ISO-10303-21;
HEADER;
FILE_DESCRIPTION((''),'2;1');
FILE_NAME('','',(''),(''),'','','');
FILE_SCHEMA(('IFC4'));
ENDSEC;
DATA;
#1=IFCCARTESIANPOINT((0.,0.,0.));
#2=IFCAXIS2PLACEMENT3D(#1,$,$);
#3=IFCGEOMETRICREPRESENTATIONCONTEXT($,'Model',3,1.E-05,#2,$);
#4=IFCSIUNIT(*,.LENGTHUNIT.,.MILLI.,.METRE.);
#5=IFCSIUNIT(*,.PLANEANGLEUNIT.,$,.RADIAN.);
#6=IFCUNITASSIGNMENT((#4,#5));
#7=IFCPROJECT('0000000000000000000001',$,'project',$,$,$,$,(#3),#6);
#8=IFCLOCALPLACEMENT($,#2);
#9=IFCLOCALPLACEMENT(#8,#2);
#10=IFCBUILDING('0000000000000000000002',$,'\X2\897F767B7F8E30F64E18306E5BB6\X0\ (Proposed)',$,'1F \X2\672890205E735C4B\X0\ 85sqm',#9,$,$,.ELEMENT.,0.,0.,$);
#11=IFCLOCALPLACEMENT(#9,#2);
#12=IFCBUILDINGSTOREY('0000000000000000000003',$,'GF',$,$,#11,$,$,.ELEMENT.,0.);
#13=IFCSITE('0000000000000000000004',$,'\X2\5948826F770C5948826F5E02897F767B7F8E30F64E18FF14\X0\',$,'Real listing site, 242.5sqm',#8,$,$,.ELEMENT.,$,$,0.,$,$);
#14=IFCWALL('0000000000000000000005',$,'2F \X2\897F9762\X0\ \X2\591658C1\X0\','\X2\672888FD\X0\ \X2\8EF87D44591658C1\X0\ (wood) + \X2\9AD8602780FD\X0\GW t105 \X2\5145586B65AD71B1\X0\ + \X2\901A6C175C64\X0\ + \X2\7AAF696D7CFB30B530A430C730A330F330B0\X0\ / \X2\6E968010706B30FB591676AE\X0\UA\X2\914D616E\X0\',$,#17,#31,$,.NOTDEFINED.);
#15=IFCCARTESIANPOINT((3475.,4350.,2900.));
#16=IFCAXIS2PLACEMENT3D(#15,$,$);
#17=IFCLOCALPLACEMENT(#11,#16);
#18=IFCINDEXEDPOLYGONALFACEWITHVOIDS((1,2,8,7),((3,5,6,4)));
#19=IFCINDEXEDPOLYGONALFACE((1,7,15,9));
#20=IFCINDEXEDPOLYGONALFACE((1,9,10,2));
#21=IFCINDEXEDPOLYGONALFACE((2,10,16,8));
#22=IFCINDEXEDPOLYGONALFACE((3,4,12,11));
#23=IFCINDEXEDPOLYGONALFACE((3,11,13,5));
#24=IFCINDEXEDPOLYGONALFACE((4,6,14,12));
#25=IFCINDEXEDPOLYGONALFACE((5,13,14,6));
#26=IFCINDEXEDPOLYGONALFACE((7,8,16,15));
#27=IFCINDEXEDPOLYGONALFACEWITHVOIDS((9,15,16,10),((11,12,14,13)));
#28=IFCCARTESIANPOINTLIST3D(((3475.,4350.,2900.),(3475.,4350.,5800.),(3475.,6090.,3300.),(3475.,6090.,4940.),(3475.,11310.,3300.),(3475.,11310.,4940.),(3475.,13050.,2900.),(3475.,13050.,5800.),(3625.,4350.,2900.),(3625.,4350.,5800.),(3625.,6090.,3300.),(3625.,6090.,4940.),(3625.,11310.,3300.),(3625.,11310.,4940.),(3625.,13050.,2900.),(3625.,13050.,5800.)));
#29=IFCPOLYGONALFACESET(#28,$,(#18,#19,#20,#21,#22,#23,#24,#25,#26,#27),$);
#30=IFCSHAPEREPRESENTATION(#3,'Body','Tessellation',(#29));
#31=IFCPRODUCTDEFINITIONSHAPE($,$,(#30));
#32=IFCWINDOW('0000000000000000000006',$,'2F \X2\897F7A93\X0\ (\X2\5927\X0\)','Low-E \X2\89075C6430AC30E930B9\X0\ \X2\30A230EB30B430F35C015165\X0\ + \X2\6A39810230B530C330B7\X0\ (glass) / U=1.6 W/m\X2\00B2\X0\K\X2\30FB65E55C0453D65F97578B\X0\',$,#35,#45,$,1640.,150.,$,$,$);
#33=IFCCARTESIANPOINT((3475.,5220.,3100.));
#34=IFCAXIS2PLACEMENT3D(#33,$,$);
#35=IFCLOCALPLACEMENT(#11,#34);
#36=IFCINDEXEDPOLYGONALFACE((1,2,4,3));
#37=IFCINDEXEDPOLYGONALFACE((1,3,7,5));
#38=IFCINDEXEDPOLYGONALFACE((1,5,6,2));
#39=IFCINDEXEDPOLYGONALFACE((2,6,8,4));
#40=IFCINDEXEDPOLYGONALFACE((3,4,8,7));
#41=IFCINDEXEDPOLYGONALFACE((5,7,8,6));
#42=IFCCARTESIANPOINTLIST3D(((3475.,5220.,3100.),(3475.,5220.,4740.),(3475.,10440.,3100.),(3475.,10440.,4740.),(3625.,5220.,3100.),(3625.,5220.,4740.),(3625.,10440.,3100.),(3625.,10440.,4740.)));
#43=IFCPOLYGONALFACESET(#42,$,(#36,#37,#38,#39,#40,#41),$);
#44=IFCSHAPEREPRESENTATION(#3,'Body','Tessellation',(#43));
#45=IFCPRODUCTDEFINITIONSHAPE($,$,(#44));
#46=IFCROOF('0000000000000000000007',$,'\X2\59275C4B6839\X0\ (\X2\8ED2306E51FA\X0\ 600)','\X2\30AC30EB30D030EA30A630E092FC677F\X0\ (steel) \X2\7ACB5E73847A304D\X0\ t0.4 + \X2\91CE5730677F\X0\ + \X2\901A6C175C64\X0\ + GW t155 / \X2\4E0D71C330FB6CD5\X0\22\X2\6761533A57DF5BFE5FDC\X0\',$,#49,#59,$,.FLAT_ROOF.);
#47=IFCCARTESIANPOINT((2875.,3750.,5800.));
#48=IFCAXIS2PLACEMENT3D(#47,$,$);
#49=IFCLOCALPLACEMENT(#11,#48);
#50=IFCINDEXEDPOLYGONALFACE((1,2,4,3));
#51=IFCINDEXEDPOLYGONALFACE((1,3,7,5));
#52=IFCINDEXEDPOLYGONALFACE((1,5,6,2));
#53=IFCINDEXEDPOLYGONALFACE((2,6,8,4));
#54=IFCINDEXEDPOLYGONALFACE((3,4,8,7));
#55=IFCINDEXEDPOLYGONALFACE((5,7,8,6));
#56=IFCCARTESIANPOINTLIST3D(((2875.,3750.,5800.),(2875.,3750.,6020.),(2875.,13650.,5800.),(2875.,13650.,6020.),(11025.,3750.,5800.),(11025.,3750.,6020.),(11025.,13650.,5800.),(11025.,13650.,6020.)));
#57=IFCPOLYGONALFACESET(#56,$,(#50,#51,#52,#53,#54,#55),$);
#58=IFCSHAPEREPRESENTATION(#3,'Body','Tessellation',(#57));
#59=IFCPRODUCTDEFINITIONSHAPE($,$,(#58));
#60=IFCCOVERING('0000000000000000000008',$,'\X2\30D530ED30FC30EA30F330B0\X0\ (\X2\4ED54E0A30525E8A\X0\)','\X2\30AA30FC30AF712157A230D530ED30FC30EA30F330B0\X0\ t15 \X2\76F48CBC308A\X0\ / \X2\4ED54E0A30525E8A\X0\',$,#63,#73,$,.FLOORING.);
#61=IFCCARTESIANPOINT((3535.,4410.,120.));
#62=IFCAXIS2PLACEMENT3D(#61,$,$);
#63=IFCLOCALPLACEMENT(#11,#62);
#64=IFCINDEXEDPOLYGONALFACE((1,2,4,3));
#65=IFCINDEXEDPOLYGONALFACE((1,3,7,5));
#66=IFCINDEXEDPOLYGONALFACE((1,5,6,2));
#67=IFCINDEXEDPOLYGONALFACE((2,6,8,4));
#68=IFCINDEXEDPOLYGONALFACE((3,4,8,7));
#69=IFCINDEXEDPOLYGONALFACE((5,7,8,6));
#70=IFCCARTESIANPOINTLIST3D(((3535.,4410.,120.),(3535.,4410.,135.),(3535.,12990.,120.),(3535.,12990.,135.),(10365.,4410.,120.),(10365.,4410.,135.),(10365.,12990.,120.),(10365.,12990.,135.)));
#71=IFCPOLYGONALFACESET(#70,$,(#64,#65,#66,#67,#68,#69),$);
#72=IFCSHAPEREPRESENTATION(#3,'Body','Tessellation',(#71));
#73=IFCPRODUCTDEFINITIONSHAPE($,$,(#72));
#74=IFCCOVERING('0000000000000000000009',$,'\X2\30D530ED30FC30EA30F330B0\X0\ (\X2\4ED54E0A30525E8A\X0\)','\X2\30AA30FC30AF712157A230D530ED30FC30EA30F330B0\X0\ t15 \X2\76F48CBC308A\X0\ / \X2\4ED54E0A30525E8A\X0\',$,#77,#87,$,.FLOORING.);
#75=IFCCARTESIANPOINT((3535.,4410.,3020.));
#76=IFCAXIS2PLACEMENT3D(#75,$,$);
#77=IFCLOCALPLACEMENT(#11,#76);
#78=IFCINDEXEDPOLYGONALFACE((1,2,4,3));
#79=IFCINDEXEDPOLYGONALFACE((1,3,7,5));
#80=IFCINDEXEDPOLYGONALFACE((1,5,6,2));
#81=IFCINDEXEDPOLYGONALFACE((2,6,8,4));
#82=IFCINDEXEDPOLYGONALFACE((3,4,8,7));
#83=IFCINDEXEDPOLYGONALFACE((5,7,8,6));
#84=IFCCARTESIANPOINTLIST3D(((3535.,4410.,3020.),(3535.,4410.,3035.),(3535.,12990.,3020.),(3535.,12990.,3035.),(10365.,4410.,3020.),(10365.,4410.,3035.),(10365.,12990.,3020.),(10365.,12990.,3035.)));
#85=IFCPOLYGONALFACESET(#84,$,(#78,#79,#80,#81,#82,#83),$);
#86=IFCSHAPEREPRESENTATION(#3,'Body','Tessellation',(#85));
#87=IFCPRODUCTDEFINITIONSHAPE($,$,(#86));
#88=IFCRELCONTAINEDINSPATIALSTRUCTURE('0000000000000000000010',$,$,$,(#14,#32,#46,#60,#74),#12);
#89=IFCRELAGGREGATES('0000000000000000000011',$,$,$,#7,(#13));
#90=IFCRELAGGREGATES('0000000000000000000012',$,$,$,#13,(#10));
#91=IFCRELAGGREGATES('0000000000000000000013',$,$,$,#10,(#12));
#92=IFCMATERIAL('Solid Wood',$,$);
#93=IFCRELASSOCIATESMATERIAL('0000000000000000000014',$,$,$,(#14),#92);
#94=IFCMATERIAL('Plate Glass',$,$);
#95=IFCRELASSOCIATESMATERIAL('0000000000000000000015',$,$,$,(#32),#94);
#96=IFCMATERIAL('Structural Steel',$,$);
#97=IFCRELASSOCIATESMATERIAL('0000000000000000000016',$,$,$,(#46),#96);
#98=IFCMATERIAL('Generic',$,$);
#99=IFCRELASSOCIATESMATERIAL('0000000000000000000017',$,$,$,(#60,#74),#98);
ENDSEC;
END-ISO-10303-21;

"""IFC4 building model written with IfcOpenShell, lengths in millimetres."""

from ifc_helpers import new_model, si_unit, frame, frame_2d, origin, place, context, project, spatial, rectangle, extrude, material, element, fill, save


model = new_model("IFC4")

# Units and contexts
model_context = context("Model", 3, precision=1e-05, world=origin())
ifc_project = project(units=[si_unit("LENGTHUNIT", "METRE", prefix="MILLI"), si_unit("PLANEANGLEUNIT", "RADIAN")], contexts=[model_context])

# Site, building, storey
site_placement = place(None, origin())
site = spatial("IfcSite", under=ifc_project, at=site_placement, Name="奈良県奈良市西登美ヶ丘４", ObjectType="Real listing site, 242.5sqm", CompositionType="ELEMENT", RefElevation=0.0)
building_placement = place(site_placement, origin())
building = spatial("IfcBuilding", under=site, at=building_placement, Name="西登美ヶ丘の家 (Proposed)", ObjectType="1F 木造平屋 85sqm", CompositionType="ELEMENT", ElevationOfRefHeight=0.0, ElevationOfTerrain=0.0)
storey_placement = place(building_placement, origin())
storey = spatial("IfcBuildingStorey", under=building, at=storey_placement, Name="GF", CompositionType="ELEMENT", Elevation=0.0)

# Shared definitions
ifc_material_1 = material(Name="Solid Wood")
ifc_material_2 = material(Name="Generic")

# Shared definitions
ifc_material_3 = material(Name="Plate Glass")

# Wall, opening, window
wall_1_placement = place(storey_placement, frame((3475.0, 4350.0, 2900.0)))
wall_1 = element("IfcWall", 1, at=wall_1_placement, inside=storey, material=ifc_material_1, Name="2F 西面 外壁", Description="木製 軸組外壁 (wood) + 高性能GW t105 充填断熱 + 通気層 + 窯業系サイディング / 準耐火・外皮UA配慮", PredefinedType="NOTDEFINED", context=model_context, shape_type="SweptSolid", body=[
    extrude(rectangle(XDim=150.0, YDim=8700.0, at=frame_2d((75.0, 4350.0))), frame((3475.0, 4350.0, 2900.0)), (0.0, 0.0, 1.0), 2900.0),
])
opening_1_placement = place(storey_placement, frame((3475.0, 5220.0, 3100.0)))
opening_1 = element("IfcOpeningElement", 2, at=opening_1_placement, cuts=wall_1, PredefinedType="NOTDEFINED", context=model_context, shape_type="SweptSolid", body=[
    extrude(rectangle(XDim=150.0, YDim=5220.0, at=frame_2d((75.0, 2610.0))), frame((3475.0, 5220.0, 3100.0)), (0.0, 0.0, 1.0), 1640.0),
])
window_1_placement = place(storey_placement, frame((3475.0, 5220.0, 3100.0)))
window_1 = element("IfcWindow", 3, at=window_1_placement, inside=storey, material=ifc_material_3, Name="2F 西窓 (大)", Description="Low-E 複層ガラス アルゴン封入 + 樹脂サッシ (glass) / U=1.6 W/m²K・日射取得型", OverallHeight=1640.0, OverallWidth=150.0, context=model_context, shape_type="SweptSolid", body=[
    extrude(rectangle(XDim=150.0, YDim=5220.0, at=frame_2d((75.0, 2610.0))), frame((3475.0, 5220.0, 3100.0)), (0.0, 0.0, 1.0), 1640.0),
])
fill(opening_1, window_1)

# Roof
ifc_material_4 = material(Name="Structural Steel")
roof_placement = place(storey_placement, frame((2875.0, 3750.0, 5800.0)))
element("IfcRoof", 4, at=roof_placement, inside=storey, material=ifc_material_4, Name="大屋根 (軒の出 600)", Description="ガルバリウム鋼板 (steel) 立平葺き t0.4 + 野地板 + 通気層 + GW t155 / 不燃・法22条区域対応", PredefinedType="FLAT_ROOF", context=model_context, shape_type="SweptSolid", body=[
    extrude(rectangle(XDim=8150.0, YDim=9900.0, at=frame_2d((4075.0, 4950.0))), frame((2875.0, 3750.0, 5800.0)), (0.0, 0.0, 1.0), 220.0),
])

# Coverings
covering_1_placement = place(storey_placement, frame((3535.0, 4410.0, 120.0)))
element("IfcCovering", 5, at=covering_1_placement, inside=storey, material=ifc_material_2, Name="フローリング (仕上げ床)", Description="オーク無垢フローリング t15 直貼り / 仕上げ床", PredefinedType="FLOORING", context=model_context, shape_type="SweptSolid", body=[
    extrude(rectangle(XDim=6830.0, YDim=8580.0, at=frame_2d((3415.0, 4290.0))), frame((3535.0, 4410.0, 120.0)), (0.0, 0.0, 1.0), 15.0),
])
covering_2_placement = place(storey_placement, frame((3535.0, 4410.0, 3020.0)))
element("IfcCovering", 6, at=covering_2_placement, inside=storey, material=ifc_material_2, Name="フローリング (仕上げ床)", Description="オーク無垢フローリング t15 直貼り / 仕上げ床", PredefinedType="FLOORING", context=model_context, shape_type="SweptSolid", body=[
    extrude(rectangle(XDim=6830.0, YDim=8580.0, at=frame_2d((3415.0, 4290.0))), frame((3535.0, 4410.0, 3020.0)), (0.0, 0.0, 1.0), 15.0),
])

save(model, "model.ifc")
